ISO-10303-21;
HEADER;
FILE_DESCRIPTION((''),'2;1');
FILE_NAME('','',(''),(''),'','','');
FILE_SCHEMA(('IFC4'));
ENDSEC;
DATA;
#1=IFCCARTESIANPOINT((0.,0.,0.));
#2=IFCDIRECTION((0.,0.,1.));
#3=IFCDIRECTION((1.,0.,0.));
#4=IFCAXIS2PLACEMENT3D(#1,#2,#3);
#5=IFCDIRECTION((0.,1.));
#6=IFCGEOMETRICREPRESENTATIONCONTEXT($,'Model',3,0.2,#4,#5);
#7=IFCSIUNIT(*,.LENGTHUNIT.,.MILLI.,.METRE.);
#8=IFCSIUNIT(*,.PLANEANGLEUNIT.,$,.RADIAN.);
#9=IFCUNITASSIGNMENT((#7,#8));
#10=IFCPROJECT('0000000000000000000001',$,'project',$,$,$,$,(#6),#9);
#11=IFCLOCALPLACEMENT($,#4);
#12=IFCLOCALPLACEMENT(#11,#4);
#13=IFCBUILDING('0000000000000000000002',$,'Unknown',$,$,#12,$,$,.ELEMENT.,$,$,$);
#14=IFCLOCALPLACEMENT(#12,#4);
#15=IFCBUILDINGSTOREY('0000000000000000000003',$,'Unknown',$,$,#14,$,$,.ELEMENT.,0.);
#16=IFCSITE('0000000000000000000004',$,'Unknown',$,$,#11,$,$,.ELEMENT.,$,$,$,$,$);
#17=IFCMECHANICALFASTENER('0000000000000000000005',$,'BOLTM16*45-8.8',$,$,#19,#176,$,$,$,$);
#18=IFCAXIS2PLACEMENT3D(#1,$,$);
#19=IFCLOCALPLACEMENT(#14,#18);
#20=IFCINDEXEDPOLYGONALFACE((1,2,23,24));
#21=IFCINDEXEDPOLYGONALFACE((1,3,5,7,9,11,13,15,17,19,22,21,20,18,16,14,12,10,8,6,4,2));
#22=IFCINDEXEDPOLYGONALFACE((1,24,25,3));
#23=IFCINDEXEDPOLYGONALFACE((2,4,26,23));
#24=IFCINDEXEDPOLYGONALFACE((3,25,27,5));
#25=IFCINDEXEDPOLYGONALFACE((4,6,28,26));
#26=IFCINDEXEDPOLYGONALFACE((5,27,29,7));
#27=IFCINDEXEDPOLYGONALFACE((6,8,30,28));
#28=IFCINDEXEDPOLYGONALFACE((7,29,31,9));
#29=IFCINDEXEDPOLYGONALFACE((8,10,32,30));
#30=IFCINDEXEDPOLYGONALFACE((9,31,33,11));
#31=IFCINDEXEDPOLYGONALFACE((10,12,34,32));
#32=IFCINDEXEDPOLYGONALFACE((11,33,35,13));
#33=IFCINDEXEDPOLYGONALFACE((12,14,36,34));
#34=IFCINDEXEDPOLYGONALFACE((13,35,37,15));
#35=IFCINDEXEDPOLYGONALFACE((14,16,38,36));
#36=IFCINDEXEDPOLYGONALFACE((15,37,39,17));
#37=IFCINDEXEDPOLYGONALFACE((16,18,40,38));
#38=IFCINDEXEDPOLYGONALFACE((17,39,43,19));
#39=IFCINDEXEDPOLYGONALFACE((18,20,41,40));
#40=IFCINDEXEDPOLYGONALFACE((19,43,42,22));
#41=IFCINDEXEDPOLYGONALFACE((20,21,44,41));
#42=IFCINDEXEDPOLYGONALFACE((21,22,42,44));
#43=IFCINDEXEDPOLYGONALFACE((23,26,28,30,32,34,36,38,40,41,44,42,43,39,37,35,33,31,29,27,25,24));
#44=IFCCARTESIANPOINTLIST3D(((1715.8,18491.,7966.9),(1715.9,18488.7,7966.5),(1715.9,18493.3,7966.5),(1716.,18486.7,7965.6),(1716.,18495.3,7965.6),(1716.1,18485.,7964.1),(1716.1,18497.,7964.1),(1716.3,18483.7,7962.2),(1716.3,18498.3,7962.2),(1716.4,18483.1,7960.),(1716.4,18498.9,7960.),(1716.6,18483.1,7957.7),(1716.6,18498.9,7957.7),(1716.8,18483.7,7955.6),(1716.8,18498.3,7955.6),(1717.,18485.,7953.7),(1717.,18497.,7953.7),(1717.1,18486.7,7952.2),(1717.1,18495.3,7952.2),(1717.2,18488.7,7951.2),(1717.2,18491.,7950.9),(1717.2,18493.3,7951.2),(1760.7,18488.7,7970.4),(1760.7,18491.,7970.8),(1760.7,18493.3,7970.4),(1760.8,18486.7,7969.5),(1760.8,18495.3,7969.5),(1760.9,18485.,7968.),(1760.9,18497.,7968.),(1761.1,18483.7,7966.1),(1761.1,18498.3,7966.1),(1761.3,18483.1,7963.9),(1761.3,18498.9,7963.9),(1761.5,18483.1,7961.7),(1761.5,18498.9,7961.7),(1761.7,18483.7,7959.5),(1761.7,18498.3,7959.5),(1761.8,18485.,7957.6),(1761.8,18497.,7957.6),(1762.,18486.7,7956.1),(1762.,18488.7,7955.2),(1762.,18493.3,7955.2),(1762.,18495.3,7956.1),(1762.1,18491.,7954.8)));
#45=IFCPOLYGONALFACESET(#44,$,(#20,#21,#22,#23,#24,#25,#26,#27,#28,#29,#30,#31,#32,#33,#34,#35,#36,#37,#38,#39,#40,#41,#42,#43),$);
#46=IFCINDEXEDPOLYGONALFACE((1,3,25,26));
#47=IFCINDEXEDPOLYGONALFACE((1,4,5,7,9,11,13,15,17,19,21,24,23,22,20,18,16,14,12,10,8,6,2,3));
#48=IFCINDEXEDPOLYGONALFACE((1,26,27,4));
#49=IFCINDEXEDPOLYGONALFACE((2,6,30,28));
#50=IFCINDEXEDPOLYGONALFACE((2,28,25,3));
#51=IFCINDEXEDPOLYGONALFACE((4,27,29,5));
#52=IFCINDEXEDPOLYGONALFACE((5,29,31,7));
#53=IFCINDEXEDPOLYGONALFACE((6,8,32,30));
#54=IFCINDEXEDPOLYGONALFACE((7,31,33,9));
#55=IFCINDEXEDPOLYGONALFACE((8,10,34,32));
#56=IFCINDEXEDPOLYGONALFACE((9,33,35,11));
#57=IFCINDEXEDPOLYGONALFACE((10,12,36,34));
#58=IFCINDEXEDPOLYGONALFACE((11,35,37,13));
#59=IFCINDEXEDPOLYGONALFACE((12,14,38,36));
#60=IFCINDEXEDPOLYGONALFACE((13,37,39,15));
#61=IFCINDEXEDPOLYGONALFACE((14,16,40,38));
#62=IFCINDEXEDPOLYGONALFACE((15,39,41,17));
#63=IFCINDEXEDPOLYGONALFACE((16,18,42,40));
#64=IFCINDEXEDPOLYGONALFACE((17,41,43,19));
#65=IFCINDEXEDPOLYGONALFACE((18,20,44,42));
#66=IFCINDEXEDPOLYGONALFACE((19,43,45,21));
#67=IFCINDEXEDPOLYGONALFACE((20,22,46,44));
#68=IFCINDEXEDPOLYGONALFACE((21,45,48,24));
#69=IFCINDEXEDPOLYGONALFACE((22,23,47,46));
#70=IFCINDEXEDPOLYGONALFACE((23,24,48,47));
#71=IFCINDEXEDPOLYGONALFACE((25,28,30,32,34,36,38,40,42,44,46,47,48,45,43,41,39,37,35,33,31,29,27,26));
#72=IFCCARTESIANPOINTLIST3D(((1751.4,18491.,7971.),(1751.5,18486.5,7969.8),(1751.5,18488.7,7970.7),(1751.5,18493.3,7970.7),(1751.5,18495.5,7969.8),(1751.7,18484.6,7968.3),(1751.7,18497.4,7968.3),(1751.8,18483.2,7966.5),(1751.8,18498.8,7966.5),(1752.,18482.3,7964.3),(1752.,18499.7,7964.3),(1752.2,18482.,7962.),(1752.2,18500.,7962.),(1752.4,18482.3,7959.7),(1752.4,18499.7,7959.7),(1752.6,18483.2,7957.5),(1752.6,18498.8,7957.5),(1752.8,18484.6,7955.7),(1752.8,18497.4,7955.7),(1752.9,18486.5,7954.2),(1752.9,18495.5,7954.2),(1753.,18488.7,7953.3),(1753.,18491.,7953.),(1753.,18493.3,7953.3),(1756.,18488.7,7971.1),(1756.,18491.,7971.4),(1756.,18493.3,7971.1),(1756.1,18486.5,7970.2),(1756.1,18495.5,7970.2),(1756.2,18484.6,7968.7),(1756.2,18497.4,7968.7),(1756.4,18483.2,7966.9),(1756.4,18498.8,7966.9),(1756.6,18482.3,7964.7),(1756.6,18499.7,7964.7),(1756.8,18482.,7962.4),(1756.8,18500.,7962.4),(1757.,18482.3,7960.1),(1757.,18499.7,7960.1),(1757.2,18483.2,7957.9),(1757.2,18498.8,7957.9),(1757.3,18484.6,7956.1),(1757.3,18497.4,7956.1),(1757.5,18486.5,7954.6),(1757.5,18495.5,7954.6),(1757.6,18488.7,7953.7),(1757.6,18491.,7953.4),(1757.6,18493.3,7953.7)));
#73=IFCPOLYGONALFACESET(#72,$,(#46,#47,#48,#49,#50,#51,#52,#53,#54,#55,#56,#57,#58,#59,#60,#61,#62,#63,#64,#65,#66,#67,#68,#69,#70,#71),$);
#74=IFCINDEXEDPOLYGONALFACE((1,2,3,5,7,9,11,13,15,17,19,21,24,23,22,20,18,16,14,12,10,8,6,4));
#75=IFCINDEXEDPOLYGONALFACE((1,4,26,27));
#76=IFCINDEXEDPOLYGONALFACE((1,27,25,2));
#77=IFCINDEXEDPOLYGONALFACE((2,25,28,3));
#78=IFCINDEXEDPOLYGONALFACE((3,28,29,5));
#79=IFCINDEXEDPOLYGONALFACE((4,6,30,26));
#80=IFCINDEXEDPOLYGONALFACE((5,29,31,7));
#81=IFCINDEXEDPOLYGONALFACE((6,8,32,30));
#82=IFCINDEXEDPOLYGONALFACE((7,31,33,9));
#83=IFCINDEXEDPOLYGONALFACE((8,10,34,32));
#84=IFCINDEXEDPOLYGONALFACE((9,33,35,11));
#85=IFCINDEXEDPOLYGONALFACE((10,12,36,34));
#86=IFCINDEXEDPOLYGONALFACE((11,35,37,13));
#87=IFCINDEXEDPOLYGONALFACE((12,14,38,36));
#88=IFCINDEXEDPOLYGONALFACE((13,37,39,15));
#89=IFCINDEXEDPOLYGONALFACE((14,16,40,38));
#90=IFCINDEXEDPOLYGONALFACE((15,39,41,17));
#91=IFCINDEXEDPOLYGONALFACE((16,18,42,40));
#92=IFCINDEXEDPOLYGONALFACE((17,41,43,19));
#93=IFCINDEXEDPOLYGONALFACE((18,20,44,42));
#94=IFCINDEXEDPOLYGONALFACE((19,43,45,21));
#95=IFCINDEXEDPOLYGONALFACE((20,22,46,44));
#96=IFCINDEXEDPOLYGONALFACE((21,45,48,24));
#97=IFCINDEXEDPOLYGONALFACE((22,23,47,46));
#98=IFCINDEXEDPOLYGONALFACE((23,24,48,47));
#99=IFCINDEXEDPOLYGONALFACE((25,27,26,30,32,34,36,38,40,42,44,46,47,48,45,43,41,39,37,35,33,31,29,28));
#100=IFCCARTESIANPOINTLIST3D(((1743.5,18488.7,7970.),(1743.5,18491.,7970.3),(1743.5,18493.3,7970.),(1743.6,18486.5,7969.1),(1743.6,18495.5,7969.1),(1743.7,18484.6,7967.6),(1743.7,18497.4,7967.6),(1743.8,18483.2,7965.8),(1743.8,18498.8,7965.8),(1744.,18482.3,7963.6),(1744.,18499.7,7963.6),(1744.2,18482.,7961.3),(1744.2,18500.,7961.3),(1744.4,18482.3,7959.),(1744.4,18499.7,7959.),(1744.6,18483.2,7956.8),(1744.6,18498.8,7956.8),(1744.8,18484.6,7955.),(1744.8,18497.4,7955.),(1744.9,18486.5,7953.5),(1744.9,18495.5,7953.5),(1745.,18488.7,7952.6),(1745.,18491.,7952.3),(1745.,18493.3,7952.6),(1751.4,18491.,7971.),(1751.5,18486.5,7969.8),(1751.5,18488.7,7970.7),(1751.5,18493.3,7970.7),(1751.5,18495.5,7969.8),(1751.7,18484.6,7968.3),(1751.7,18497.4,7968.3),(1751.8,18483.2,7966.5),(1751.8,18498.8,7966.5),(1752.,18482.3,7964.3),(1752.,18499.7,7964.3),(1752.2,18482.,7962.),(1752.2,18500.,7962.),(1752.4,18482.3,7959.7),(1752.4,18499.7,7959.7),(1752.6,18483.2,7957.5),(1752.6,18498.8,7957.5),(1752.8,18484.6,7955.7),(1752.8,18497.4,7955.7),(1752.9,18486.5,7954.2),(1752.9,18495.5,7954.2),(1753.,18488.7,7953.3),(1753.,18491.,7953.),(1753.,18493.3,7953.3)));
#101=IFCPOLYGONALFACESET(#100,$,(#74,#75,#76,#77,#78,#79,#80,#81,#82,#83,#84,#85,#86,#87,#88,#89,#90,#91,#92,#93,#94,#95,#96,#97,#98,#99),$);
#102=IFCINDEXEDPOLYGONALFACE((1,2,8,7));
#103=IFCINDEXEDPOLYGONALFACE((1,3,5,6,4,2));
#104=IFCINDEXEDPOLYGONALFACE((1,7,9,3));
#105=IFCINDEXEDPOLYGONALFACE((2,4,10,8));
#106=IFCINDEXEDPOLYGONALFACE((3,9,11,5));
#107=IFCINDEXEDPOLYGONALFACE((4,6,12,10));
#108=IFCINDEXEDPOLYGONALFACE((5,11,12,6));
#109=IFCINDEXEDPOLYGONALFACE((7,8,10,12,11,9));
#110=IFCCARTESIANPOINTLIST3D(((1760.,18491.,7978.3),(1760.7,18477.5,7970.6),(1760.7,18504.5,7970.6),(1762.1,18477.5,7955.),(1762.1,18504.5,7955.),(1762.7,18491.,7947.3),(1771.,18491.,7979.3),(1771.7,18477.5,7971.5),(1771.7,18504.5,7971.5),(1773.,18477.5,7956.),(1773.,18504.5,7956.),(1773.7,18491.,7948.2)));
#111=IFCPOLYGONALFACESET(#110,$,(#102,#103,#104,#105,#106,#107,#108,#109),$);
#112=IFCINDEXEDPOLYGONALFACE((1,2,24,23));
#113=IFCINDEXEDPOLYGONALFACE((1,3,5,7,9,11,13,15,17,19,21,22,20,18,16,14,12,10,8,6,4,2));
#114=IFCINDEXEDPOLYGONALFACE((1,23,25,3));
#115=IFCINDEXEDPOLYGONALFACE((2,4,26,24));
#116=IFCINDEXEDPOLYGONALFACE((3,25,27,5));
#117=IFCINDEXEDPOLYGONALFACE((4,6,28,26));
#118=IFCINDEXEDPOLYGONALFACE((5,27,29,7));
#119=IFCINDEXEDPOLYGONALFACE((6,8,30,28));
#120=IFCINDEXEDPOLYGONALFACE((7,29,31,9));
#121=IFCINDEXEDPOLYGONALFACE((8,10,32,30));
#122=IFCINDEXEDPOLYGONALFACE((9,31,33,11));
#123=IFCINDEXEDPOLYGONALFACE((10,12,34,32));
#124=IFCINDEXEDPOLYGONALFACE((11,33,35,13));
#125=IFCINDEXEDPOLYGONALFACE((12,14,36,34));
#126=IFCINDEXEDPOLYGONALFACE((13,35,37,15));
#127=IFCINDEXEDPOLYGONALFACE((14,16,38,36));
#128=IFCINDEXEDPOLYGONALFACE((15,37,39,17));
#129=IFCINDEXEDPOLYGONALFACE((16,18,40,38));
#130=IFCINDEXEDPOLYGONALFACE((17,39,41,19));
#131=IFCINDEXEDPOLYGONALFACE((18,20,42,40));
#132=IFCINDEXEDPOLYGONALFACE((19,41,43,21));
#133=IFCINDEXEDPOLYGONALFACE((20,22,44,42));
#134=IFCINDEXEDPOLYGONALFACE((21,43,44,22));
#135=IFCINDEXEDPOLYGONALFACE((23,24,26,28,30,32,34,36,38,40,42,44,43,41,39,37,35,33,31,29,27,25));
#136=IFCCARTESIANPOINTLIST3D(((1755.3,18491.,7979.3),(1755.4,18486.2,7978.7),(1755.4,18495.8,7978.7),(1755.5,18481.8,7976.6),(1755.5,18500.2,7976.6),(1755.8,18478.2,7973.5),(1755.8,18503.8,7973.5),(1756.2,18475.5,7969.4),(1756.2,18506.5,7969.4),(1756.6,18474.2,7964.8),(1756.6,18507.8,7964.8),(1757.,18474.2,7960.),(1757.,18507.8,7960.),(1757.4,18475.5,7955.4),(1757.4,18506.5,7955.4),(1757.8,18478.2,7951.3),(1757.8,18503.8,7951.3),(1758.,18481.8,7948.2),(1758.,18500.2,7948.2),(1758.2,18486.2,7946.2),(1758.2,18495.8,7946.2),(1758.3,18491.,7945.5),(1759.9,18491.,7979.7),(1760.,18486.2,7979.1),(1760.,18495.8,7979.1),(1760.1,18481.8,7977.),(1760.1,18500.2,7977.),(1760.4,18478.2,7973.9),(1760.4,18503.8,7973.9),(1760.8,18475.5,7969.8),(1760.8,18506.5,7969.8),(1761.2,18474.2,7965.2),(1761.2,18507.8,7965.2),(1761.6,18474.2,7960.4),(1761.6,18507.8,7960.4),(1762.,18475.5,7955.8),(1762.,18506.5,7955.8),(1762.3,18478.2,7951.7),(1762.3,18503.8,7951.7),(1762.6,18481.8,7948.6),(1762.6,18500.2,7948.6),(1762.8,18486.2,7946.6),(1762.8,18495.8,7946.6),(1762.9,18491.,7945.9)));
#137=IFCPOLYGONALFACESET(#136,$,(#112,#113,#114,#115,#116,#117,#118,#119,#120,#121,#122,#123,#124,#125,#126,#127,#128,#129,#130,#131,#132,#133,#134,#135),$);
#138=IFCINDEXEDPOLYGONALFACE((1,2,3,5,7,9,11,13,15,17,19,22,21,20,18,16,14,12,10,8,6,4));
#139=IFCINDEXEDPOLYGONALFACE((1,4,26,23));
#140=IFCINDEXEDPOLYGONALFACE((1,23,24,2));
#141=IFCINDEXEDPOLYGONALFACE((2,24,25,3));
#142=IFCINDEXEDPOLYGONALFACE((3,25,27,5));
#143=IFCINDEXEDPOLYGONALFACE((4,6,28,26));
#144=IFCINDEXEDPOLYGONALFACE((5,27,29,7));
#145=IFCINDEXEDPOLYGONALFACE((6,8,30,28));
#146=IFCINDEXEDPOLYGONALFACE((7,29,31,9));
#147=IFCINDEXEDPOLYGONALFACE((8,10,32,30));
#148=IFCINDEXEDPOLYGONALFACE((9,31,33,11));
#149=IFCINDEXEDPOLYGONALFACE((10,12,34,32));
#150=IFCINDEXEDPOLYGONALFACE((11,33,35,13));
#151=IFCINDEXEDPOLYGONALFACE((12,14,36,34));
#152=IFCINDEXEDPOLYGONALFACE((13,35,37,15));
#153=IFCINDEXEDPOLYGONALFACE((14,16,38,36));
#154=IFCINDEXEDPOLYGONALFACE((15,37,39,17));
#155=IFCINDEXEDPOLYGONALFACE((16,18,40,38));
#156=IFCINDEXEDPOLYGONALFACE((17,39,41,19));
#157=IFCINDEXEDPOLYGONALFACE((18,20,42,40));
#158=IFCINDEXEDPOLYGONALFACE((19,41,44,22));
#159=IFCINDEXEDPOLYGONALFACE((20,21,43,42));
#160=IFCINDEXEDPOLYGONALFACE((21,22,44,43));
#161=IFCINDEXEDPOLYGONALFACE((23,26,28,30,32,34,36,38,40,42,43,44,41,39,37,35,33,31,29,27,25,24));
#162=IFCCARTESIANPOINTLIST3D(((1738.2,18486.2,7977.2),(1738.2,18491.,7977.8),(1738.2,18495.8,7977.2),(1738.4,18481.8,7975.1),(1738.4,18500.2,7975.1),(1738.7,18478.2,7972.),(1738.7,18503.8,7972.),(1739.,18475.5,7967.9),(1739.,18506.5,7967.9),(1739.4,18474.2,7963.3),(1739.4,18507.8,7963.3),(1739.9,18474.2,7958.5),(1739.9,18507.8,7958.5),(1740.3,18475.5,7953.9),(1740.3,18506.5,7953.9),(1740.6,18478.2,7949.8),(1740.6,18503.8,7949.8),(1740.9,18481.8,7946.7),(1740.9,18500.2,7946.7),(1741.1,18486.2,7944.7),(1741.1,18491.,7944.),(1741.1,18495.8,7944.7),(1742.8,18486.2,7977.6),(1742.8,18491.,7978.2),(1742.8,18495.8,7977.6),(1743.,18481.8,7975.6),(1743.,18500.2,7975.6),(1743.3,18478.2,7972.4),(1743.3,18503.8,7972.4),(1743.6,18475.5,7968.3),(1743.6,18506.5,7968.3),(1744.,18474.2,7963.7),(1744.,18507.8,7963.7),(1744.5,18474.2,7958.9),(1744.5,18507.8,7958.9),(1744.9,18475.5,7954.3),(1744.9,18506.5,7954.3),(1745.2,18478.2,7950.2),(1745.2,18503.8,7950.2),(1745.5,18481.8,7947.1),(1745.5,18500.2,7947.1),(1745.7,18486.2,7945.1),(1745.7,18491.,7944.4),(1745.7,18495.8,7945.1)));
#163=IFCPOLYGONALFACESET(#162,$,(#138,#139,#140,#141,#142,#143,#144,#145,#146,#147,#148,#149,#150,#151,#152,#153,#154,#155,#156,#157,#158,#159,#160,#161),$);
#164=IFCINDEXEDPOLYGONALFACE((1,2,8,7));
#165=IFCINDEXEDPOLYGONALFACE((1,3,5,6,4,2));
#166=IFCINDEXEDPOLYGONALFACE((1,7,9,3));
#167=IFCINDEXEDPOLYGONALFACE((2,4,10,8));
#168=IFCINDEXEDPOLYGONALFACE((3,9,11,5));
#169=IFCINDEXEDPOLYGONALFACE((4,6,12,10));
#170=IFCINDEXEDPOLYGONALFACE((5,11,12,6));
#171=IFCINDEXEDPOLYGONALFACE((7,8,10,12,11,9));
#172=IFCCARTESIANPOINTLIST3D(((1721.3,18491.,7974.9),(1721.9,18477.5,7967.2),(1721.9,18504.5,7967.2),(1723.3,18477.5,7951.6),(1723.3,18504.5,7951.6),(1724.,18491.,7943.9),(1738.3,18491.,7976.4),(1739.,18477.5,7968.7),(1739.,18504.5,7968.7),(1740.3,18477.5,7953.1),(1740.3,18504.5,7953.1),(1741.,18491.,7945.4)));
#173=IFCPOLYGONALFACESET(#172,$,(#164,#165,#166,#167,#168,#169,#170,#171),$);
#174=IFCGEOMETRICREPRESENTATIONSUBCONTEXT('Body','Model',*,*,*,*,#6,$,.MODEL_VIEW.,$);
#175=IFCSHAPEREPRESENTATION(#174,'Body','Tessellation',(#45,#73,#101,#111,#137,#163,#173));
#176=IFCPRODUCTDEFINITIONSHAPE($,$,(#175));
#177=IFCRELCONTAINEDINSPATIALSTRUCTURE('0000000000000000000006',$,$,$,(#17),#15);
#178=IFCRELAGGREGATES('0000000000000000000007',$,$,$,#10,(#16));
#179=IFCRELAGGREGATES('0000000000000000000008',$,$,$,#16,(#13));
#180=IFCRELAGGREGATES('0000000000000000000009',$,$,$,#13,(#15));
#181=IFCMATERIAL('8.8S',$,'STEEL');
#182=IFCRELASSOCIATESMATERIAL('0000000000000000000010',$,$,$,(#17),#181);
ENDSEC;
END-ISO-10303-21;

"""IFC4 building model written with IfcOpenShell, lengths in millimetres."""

from ifc_helpers import new_model, si_unit, direction, frame, origin_with_axes, place, context, subcontext, project, spatial, line, arc, indexed_curve, outline, extrude, source, transform, mapped, material, element, save


model = new_model("IFC4")

# Units and contexts
model_context = context("Model", 3, precision=0.2, world=origin_with_axes(), true_north=direction((0.0, 1.0)))
body_context = subcontext(model_context, "Body", "Model", "MODEL_VIEW")
ifc_project = project(units=[si_unit("LENGTHUNIT", "METRE", prefix="MILLI"), si_unit("PLANEANGLEUNIT", "RADIAN")], contexts=[model_context])

# Site, building, storey
site_placement = place(None, origin_with_axes())
site = spatial("IfcSite", under=ifc_project, at=site_placement, Name="Unknown", CompositionType="ELEMENT")
building_placement = place(site_placement, origin_with_axes())
building = spatial("IfcBuilding", under=site, at=building_placement, Name="Unknown", CompositionType="ELEMENT")
storey_placement = place(building_placement, origin_with_axes())
storey = spatial("IfcBuildingStorey", under=building, at=storey_placement, Name="Unknown", CompositionType="ELEMENT", Elevation=0.0)

# Mechanical fastener
ifc_material_1 = material(Name="8.8S", Category="STEEL")
shared_shape_1 = source(origin_with_axes(), body_context, "Body", "SweptSolid", [
    extrude(outline(indexed_curve([(8.0, 0.0), (0.0, 8.0), (-8.0, 0.0), (0.0, -8.0)], segments=[arc(1, 2, 3), arc(3, 4, 1)])), frame((0.0, 0.0, 9.2), z_axis=(0.0, 0.0, -1.0), x_axis=(0.0, 1.0, 0.0)), (0.0, 0.0, 1.0), 45.0),
    extrude(outline(indexed_curve([(0.0, 9.0), (6.4, 6.4), (9.0, 0.0), (6.4, -6.4), (0.0, -9.0), (-0.8, -9.0), (-9.0, 0.0), (-6.4, 6.4)], segments=[arc(1, 2, 3), arc(3, 4, 5), arc(5, 6, 7), arc(7, 8, 1)])), frame((0.0, 0.0, 4.6), z_axis=(0.0, 0.0, -1.0), x_axis=(0.0, 1.0, 0.0)), (0.0, 0.0, 1.0), 4.6),
    extrude(outline(indexed_curve([(0.0, 9.0), (6.4, 6.4), (9.0, 0.0), (6.4, -6.4), (0.0, -9.0), (-0.8, -9.0), (-9.0, 0.0), (-6.4, 6.4)], segments=[arc(1, 2, 3), arc(3, 4, 5), arc(5, 6, 7), arc(7, 8, 1)])), frame((0.0, 0.0, 0.0), z_axis=(0.0, 0.0, -1.0), x_axis=(0.0, 1.0, 0.0)), (0.0, 0.0, 1.0), 8.0),
    extrude(outline(indexed_curve([(15.6, 0.0), (7.8, 13.5), (-7.8, 13.5), (-15.6, 0.0), (-7.8, -13.5), (7.8, -13.5)], segments=[line(1, 2, 3, 4, 5, 6, 1)])), frame((0.0, 0.0, 20.2), z_axis=(0.0, 0.0, -1.0), x_axis=(0.0, 1.0, 0.0)), (0.0, 0.0, 1.0), 11.0),
    extrude(outline(indexed_curve([(17.0, 0.0), (0.0, 17.0), (-17.0, 0.0), (0.0, -17.0)], segments=[arc(1, 2, 3), arc(3, 4, 1)])), frame((0.0, 0.0, 9.2), z_axis=(0.0, 0.0, -1.0), x_axis=(0.0, 1.0, 0.0)), (0.0, 0.0, 1.0), 4.6),
    extrude(outline(indexed_curve([(17.0, 0.0), (0.0, 17.0), (-17.0, 0.0), (0.0, -17.0)], segments=[arc(1, 2, 3), arc(3, 4, 1)])), frame((0.0, 0.0, -8.0), z_axis=(0.0, 0.0, -1.0), x_axis=(0.0, 1.0, 0.0)), (0.0, 0.0, 1.0), 4.6),
    extrude(outline(indexed_curve([(15.6, 0.0), (7.8, 13.5), (-7.8, 13.5), (-15.6, 0.0), (-7.8, -13.5), (7.8, -13.5)], segments=[line(1, 2, 3, 4, 5, 6, 1)])), frame((0.0, 0.0, -12.6), z_axis=(0.0, 0.0, -1.0), x_axis=(0.0, 1.0, 0.0)), (0.0, 0.0, 1.0), 17.1),
])
mechanical_fastener_1_placement = place(storey_placement, frame((1752.2, 18491.0, 7962.0), z_axis=(0.996195, 0.0, 0.087156), x_axis=(0.0, 1.0, 0.0)))
element("IfcMechanicalFastener", 1, at=mechanical_fastener_1_placement, inside=storey, material=ifc_material_1, Name="BOLTM16*45-8.8", context=body_context, shape_type="MappedRepresentation", body=[
    mapped(shared_shape_1, transform((0.0, 0.0, 0.0))),
])

save(model, "model.ifc")
